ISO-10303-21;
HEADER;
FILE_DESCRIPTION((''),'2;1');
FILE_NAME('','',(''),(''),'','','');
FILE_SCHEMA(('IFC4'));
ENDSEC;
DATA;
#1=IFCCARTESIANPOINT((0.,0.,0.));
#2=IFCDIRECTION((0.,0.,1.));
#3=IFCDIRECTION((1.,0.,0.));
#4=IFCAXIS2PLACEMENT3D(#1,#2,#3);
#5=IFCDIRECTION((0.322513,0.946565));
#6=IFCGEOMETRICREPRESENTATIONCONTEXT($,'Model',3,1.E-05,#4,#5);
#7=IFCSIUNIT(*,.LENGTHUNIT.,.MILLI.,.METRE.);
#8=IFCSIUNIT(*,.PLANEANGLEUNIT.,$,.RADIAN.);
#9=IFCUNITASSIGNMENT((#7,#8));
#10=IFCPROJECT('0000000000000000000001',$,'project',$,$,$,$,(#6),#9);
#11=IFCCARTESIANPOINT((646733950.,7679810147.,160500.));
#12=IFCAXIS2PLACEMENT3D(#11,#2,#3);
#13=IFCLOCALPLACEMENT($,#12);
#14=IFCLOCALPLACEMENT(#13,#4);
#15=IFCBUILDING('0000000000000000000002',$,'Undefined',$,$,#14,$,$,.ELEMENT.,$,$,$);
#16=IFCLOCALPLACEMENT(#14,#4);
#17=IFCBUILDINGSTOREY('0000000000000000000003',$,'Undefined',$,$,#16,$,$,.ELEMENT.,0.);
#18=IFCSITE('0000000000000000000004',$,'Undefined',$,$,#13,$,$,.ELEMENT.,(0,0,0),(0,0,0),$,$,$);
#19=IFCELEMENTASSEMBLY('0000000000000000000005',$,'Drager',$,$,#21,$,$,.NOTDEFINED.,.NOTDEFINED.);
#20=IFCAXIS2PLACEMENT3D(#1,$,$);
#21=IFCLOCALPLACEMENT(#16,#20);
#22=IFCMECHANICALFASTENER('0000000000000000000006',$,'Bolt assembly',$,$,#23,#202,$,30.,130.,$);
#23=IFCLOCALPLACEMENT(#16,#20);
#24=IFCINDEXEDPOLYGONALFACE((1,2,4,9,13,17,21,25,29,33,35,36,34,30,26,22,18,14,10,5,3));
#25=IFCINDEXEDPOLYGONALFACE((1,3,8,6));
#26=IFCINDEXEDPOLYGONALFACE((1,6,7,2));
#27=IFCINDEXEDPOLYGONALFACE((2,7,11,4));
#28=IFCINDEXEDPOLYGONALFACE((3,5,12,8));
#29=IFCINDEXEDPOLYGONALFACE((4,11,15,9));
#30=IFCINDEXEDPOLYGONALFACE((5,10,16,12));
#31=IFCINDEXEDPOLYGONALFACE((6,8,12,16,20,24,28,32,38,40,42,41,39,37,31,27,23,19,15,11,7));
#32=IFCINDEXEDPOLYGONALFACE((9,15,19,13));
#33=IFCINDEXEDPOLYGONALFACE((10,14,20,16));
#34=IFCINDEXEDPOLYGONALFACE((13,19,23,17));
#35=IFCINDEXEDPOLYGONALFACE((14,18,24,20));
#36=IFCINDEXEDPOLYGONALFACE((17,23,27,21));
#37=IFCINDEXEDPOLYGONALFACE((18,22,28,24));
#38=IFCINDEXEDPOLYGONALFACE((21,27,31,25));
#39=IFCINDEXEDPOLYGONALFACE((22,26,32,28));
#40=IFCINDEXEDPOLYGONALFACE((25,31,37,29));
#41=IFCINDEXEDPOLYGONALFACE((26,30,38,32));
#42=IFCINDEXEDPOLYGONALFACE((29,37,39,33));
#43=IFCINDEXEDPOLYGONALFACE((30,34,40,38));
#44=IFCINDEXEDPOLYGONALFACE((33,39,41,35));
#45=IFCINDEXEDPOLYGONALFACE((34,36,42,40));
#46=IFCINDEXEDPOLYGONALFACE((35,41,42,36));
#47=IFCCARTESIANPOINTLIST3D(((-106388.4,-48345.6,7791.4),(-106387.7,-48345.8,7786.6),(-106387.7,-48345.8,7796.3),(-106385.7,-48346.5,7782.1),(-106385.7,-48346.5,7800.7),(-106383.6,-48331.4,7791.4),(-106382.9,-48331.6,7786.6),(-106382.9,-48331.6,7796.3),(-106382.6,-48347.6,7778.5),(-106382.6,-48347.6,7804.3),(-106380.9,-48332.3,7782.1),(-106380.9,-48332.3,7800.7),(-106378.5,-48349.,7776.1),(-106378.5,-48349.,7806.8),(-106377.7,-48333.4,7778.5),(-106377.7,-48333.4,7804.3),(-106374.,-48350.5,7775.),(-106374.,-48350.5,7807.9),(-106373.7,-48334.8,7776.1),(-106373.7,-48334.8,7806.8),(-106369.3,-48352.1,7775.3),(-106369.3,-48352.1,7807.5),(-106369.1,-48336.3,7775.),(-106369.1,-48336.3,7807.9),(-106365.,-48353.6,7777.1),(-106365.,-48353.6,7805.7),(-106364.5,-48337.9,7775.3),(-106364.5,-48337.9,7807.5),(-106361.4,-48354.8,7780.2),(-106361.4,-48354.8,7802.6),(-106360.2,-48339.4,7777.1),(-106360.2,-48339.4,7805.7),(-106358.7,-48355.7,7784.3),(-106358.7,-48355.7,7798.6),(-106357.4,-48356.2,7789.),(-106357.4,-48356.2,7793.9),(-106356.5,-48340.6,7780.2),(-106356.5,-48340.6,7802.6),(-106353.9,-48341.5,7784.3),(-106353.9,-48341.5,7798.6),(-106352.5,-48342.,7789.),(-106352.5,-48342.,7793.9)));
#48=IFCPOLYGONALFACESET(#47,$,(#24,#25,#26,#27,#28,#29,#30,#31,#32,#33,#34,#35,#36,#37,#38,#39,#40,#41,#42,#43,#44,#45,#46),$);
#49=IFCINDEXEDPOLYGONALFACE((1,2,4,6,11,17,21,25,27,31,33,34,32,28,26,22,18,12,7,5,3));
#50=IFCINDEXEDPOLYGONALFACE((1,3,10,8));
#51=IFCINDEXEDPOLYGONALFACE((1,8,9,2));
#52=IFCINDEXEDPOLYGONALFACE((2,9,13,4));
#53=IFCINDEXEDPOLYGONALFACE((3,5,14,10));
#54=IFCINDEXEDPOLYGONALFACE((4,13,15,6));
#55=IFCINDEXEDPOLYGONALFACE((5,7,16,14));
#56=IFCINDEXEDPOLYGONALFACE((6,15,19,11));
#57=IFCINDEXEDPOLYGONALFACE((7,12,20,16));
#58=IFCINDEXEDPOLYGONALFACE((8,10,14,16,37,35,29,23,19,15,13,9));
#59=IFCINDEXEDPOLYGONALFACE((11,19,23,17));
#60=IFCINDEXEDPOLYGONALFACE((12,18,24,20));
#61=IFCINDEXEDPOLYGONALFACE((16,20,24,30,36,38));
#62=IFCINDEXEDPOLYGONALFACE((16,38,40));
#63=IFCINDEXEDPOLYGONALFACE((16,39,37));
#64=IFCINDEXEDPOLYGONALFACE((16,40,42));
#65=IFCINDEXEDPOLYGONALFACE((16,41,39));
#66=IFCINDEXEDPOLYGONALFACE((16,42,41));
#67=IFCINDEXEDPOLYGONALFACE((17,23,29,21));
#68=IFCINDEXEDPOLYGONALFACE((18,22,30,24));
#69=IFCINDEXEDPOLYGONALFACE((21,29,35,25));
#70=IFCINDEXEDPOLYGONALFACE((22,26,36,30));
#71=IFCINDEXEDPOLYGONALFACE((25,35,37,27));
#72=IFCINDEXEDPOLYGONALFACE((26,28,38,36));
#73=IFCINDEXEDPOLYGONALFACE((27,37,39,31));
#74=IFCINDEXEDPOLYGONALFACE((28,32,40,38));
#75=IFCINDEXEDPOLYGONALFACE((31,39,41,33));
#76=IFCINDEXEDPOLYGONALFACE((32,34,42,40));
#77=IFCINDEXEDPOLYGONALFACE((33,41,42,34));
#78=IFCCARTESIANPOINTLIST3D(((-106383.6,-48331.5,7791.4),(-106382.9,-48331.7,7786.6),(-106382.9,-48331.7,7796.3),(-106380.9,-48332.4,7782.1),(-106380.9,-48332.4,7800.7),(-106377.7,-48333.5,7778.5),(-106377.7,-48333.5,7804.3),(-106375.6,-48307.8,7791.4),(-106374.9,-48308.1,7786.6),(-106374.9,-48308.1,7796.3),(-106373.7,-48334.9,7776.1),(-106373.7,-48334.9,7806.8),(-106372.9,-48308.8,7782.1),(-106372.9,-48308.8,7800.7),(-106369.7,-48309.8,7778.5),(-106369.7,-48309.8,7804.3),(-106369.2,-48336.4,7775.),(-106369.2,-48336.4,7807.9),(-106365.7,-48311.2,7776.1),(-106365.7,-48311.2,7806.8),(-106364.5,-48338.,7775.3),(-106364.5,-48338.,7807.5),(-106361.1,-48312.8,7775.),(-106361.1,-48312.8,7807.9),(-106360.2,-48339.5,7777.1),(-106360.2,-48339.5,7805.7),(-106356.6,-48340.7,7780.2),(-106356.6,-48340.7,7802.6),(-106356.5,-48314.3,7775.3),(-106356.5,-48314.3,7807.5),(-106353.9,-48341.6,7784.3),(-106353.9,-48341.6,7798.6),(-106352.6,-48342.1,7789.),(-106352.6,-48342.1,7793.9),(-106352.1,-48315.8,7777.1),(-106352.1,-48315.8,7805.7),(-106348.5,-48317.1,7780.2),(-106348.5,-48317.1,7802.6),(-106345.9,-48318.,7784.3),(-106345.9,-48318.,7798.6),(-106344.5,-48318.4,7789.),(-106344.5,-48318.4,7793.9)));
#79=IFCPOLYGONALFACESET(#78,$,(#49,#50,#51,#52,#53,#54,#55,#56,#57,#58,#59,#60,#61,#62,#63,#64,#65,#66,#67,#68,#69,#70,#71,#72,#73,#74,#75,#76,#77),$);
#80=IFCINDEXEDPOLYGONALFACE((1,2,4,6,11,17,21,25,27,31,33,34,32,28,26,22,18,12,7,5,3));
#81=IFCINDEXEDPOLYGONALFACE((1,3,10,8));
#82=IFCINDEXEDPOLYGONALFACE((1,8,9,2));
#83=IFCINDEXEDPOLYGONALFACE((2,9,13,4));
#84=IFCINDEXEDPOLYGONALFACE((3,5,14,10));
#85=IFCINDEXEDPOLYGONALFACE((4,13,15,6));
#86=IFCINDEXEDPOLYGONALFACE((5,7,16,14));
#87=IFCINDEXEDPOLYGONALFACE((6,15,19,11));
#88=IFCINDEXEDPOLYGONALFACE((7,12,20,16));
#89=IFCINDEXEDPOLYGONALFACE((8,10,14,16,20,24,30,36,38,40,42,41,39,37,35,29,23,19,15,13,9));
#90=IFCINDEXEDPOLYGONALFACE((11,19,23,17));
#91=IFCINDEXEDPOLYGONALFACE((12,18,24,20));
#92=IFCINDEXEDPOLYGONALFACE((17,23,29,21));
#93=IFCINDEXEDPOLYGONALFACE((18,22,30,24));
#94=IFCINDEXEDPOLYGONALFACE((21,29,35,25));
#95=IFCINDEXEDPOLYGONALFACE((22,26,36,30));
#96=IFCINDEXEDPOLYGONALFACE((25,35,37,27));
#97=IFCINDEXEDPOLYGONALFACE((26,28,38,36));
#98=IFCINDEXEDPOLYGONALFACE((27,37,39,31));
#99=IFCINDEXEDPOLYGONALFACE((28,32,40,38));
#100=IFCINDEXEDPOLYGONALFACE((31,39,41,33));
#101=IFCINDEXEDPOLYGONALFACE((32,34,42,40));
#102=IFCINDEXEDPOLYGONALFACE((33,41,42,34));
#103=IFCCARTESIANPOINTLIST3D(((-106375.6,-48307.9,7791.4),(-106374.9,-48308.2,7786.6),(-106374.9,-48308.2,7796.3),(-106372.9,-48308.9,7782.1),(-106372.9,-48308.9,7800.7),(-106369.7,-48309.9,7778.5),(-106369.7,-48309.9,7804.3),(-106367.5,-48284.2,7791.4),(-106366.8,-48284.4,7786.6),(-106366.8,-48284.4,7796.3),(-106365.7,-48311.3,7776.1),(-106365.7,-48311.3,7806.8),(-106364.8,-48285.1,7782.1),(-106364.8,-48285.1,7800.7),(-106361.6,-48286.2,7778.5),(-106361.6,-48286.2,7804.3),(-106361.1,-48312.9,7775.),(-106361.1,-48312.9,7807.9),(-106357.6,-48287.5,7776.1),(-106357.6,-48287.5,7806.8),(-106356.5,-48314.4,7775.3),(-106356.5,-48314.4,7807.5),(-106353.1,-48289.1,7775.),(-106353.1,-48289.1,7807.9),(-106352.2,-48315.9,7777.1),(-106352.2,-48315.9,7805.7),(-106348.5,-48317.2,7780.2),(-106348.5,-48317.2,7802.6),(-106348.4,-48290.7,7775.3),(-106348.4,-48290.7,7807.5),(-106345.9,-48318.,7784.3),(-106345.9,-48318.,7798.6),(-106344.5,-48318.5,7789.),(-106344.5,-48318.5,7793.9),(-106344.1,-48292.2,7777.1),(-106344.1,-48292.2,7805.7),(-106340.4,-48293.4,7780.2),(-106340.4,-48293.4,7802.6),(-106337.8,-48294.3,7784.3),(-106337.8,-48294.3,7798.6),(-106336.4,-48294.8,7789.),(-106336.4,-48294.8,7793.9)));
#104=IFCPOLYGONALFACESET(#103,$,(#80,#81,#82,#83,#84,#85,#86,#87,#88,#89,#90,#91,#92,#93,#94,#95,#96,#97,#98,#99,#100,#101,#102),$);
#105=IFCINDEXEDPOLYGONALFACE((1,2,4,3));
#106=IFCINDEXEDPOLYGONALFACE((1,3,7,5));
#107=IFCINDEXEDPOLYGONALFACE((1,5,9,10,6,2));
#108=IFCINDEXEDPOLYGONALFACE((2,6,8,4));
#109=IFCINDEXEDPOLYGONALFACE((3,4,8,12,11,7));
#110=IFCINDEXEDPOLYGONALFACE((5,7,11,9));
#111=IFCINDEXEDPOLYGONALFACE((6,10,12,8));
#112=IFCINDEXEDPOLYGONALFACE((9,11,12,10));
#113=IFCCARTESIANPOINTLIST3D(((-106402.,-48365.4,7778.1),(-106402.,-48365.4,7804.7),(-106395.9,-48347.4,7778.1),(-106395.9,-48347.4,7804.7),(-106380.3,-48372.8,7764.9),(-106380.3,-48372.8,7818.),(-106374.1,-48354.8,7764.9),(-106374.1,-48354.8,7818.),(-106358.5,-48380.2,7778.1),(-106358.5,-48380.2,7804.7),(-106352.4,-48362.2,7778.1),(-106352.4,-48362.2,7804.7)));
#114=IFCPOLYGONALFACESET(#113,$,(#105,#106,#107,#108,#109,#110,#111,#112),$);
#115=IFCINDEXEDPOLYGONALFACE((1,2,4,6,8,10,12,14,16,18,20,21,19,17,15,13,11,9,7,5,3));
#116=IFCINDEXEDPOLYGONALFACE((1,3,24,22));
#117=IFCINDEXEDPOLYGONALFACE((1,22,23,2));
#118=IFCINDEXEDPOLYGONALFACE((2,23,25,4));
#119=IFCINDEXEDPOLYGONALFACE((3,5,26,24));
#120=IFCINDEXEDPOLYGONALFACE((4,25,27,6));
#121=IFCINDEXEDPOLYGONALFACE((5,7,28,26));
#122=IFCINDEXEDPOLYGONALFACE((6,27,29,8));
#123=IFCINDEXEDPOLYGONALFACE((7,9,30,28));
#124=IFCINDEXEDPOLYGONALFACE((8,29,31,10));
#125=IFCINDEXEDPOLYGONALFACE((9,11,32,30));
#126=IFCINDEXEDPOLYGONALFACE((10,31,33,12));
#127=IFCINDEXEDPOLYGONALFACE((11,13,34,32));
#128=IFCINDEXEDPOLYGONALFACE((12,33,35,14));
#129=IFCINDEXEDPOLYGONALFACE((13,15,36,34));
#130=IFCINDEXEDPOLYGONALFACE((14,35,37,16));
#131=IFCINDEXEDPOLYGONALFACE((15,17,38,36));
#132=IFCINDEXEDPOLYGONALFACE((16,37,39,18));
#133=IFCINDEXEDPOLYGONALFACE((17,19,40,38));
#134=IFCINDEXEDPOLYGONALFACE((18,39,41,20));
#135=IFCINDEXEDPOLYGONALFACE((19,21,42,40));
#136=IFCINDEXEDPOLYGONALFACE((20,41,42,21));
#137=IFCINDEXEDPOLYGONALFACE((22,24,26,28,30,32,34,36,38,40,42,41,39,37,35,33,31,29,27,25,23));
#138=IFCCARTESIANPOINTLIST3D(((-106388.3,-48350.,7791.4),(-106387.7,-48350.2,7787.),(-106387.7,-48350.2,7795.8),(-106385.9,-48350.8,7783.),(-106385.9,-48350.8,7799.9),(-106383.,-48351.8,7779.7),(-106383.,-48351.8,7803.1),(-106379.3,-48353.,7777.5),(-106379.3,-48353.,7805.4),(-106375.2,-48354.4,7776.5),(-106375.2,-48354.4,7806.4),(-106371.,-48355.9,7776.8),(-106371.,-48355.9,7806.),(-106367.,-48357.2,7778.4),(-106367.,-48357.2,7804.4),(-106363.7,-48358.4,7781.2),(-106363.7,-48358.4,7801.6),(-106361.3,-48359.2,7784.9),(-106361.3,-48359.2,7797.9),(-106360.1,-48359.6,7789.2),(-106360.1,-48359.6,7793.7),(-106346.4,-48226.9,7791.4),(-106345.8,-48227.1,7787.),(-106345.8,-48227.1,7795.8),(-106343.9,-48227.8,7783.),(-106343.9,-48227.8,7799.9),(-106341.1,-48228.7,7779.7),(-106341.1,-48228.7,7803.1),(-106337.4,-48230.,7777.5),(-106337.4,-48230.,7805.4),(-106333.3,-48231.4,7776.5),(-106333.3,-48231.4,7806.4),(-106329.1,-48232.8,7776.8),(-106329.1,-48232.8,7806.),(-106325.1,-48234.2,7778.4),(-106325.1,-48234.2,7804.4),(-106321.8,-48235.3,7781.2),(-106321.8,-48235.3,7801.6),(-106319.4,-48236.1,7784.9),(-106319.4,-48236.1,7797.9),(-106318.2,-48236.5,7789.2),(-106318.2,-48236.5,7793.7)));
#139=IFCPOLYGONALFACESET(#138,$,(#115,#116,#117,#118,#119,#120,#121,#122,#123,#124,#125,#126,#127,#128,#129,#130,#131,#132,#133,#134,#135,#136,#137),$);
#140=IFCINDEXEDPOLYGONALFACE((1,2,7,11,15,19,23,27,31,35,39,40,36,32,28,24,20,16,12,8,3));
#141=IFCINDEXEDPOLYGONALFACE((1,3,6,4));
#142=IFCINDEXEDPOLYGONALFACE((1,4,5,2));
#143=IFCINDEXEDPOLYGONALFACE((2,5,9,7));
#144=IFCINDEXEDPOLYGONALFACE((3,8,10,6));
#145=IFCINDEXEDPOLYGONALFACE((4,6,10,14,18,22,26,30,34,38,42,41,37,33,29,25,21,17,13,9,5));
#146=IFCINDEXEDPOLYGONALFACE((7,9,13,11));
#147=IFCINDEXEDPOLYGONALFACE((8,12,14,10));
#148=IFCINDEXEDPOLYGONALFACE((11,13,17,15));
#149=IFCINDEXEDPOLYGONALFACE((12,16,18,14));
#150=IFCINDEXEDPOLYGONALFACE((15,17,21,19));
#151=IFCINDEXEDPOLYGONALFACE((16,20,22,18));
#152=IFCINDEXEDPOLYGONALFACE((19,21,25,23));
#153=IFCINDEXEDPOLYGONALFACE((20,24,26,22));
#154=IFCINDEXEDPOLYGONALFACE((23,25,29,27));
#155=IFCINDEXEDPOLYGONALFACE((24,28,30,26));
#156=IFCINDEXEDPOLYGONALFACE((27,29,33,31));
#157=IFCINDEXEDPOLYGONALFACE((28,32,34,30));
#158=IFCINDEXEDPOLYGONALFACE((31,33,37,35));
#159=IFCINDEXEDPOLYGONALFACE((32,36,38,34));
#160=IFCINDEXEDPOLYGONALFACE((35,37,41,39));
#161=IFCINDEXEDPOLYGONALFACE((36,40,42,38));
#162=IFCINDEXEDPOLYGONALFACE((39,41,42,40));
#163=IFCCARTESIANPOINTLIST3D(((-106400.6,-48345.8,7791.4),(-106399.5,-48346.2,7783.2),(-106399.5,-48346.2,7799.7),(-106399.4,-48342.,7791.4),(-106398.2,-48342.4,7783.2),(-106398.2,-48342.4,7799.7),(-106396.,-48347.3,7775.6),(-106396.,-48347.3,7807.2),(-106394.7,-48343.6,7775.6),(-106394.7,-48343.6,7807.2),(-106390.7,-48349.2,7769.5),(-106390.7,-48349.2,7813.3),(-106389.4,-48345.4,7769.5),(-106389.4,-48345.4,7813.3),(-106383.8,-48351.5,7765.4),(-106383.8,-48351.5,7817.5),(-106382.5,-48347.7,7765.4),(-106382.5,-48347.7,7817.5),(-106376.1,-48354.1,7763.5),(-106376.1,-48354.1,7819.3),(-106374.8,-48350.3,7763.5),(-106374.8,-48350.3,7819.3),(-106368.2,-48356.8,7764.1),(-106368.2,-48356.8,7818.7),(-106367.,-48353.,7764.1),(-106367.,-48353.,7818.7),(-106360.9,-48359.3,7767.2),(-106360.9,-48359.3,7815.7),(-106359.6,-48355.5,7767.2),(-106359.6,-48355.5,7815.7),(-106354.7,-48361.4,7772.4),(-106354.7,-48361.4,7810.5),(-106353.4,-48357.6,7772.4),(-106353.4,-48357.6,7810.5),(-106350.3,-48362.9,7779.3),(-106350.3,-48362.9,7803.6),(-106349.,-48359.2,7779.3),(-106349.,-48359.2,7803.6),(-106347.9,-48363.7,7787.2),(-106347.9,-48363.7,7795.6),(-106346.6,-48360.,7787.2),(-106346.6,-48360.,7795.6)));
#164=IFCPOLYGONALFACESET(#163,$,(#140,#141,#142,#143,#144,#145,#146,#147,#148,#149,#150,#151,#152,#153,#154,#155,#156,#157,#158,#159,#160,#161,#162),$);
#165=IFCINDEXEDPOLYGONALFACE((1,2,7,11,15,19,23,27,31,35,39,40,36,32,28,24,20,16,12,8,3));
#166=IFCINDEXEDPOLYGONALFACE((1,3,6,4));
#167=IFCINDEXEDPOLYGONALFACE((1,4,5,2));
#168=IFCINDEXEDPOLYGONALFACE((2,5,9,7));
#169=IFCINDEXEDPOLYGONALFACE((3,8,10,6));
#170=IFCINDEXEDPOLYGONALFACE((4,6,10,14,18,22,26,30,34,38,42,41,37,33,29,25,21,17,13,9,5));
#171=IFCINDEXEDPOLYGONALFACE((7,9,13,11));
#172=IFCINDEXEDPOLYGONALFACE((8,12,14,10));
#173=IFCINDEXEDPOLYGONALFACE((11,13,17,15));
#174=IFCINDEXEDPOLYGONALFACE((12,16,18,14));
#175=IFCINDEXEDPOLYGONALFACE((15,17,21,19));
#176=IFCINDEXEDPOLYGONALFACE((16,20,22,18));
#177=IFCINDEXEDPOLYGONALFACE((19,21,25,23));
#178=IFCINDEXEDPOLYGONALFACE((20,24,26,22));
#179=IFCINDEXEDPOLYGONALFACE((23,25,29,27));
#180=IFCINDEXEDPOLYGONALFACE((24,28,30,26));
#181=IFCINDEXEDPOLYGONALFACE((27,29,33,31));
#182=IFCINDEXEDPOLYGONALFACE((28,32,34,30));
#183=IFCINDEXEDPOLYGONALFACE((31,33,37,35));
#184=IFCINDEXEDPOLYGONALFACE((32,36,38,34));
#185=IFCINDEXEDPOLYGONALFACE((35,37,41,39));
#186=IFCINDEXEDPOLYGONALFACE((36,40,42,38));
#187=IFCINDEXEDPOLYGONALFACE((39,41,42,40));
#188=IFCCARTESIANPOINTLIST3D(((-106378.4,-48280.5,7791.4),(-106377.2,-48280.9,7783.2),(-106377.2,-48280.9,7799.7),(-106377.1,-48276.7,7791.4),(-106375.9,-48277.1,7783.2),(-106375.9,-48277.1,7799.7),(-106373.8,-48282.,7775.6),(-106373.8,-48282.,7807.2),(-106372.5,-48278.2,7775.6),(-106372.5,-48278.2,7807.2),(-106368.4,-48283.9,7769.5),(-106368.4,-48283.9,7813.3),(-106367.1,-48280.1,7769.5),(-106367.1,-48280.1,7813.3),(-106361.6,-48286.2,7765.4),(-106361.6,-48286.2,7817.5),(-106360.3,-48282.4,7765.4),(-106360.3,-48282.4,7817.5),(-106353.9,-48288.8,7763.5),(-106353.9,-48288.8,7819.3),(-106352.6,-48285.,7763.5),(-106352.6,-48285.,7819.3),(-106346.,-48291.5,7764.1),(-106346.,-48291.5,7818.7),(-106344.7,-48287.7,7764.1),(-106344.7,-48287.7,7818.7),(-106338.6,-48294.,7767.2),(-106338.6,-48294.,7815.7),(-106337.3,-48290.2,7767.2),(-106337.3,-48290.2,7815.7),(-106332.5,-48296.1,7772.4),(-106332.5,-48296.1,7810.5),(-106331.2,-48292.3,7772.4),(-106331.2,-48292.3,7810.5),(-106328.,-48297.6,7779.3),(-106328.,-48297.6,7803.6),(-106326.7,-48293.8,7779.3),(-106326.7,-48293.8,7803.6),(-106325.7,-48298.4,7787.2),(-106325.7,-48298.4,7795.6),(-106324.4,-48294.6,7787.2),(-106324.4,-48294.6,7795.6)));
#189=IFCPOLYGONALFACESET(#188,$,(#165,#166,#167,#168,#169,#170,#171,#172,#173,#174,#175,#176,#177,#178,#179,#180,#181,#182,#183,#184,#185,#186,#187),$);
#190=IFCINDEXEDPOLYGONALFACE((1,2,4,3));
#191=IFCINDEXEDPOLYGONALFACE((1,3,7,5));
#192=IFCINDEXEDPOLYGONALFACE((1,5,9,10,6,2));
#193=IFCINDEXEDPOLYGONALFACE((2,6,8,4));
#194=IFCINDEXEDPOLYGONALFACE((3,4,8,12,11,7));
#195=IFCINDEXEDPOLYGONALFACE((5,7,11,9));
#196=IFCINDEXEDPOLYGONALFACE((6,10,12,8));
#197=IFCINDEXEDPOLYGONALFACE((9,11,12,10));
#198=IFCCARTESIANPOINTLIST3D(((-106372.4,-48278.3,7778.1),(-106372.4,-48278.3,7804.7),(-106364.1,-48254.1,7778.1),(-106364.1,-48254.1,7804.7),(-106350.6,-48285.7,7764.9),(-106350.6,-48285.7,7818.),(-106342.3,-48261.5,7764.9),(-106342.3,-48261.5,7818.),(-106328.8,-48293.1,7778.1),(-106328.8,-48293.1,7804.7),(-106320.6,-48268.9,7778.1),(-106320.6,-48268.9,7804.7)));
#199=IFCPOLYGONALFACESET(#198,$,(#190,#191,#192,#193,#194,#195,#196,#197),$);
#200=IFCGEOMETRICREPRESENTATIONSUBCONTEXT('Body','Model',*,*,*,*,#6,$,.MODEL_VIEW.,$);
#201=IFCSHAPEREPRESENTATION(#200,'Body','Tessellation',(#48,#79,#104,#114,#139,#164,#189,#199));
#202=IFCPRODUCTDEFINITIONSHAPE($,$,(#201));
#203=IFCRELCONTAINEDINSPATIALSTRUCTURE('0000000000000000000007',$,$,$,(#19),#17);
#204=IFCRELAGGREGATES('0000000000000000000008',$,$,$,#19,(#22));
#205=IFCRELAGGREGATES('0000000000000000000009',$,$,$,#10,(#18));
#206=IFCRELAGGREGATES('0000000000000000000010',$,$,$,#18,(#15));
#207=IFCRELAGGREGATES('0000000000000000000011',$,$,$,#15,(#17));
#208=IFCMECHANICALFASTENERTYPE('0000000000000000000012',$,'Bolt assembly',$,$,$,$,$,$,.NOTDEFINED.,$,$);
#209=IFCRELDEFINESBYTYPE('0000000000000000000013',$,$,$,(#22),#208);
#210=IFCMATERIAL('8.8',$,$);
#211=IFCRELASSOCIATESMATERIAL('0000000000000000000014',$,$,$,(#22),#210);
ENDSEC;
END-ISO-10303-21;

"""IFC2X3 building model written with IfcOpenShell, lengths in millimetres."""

from ifc_helpers import new_model, si_unit, direction, frame, origin_with_axes, origin_2d_with_axis, place, context, subcontext, project, spatial, polyline, circle, outline, extrude, source, transform, mapped, material, type_object, element, aggregate, save


model = new_model("IFC2X3")

# Units and contexts
model_context = context("Model", 3, precision=1e-05, world=origin_with_axes(), true_north=direction((0.322513, 0.946565)))
body_context = subcontext(model_context, "Body", "Model", "MODEL_VIEW")
ifc_project = project(units=[si_unit("LENGTHUNIT", "METRE", prefix="MILLI"), si_unit("PLANEANGLEUNIT", "RADIAN")], contexts=[model_context])

# Site, building, storey
site_placement = place(None, frame((646733950.0, 7679810147.0, 160500.0), z_axis=(0.0, 0.0, 1.0), x_axis=(1.0, 0.0, 0.0)))
site = spatial("IfcSite", under=ifc_project, at=site_placement, Name="Undefined", CompositionType="ELEMENT", RefLatitude=(0, 0, 0), RefLongitude=(0, 0, 0))
building_placement = place(site_placement, origin_with_axes())
building = spatial("IfcBuilding", under=site, at=building_placement, Name="Undefined", CompositionType="ELEMENT")
storey_placement = place(building_placement, origin_with_axes())
storey = spatial("IfcBuildingStorey", under=building, at=storey_placement, Name="Undefined", CompositionType="ELEMENT", Elevation=0.0)

# Element assembly
assembly_1_placement = place(storey_placement, origin_with_axes())
assembly_1 = element("IfcElementAssembly", 1, at=assembly_1_placement, inside=storey, Name="Drager", AssemblyPlace="NOTDEFINED", PredefinedType="NOTDEFINED")

# Mechanical fastener
ifc_material_1 = material(Name="8.8")
mechanical_fastener_type = type_object("IfcMechanicalFastenerType", Name="Bolt assembly")
shared_shape_1 = source(origin_with_axes(), body_context, "Body", "SweptSolid", [
    extrude(circle(Radius=16.5, at=origin_2d_with_axis()), frame((0.0, -7.4, 0.0), z_axis=(0.0, 1.0, 0.0), x_axis=(1.0, 0.0, 0.0)), (0.0, 0.0, 1.0), 15.0),
    extrude(circle(Radius=16.5, at=origin_2d_with_axis()), frame((0.0, 7.5, 0.0), z_axis=(0.0, 1.0, 0.0), x_axis=(1.0, 0.0, 0.0)), (0.0, 0.0, 1.0), 25.0),
    extrude(circle(Radius=16.5, at=origin_2d_with_axis()), frame((0.0, 32.4, 0.0), z_axis=(0.0, 1.0, 0.0), x_axis=(1.0, 0.0, 0.0)), (0.0, 0.0, 1.0), 25.1),
    extrude(outline(polyline([(23.0, -13.3), (23.0, 13.3), (0.0, 26.6), (-23.0, 13.3), (-23.0, -13.3), (0.0, -26.6), (23.0, -13.3)])), frame((0.0, -30.5, 0.0), z_axis=(0.0, 1.0, 0.0), x_axis=(1.0, 0.0, 0.0)), (0.0, 0.0, 1.0), 19.0),
    extrude(circle(Radius=15.0, at=origin_2d_with_axis()), frame((0.0, -11.5, 0.0), z_axis=(0.0, 1.0, 0.0), x_axis=(1.0, 0.0, 0.0)), (0.0, 0.0, 1.0), 130.0),
    extrude(circle(Radius=28.0, at=origin_2d_with_axis()), frame((0.0, -11.5, 0.0), z_axis=(0.0, 1.0, 0.0), x_axis=(1.0, 0.0, 0.0)), (0.0, 0.0, 1.0), 4.0),
    extrude(circle(Radius=28.0, at=origin_2d_with_axis()), frame((0.0, 57.5, 0.0), z_axis=(0.0, 1.0, 0.0), x_axis=(1.0, 0.0, 0.0)), (0.0, 0.0, 1.0), 4.0),
    extrude(outline(polyline([(23.0, -13.3), (23.0, 13.3), (0.0, 26.6), (-23.0, 13.3), (-23.0, -13.3), (0.0, -26.6), (23.0, -13.3)])), frame((0.0, 61.5, 0.0), z_axis=(0.0, 1.0, 0.0), x_axis=(1.0, 0.0, 0.0)), (0.0, 0.0, 1.0), 25.6),
])
mechanical_fastener_1_placement = place(assembly_1_placement, frame((-106370.4, -48343.9, 7791.4), z_axis=(0.0, 0.0, -1.0), x_axis=(-0.946565, 0.322513, 0.0)))
mechanical_fastener_1 = element("IfcMechanicalFastener", 2, at=mechanical_fastener_1_placement, type_object=mechanical_fastener_type, material=ifc_material_1, Name="Bolt assembly", NominalDiameter=30.0, NominalLength=130.0, context=body_context, shape_type="MappedRepresentation", body=[
    mapped(shared_shape_1, transform((0.0, 0.0, 0.0))),
])

aggregate(assembly_1, [mechanical_fastener_1])

save(model, "model.ifc")
